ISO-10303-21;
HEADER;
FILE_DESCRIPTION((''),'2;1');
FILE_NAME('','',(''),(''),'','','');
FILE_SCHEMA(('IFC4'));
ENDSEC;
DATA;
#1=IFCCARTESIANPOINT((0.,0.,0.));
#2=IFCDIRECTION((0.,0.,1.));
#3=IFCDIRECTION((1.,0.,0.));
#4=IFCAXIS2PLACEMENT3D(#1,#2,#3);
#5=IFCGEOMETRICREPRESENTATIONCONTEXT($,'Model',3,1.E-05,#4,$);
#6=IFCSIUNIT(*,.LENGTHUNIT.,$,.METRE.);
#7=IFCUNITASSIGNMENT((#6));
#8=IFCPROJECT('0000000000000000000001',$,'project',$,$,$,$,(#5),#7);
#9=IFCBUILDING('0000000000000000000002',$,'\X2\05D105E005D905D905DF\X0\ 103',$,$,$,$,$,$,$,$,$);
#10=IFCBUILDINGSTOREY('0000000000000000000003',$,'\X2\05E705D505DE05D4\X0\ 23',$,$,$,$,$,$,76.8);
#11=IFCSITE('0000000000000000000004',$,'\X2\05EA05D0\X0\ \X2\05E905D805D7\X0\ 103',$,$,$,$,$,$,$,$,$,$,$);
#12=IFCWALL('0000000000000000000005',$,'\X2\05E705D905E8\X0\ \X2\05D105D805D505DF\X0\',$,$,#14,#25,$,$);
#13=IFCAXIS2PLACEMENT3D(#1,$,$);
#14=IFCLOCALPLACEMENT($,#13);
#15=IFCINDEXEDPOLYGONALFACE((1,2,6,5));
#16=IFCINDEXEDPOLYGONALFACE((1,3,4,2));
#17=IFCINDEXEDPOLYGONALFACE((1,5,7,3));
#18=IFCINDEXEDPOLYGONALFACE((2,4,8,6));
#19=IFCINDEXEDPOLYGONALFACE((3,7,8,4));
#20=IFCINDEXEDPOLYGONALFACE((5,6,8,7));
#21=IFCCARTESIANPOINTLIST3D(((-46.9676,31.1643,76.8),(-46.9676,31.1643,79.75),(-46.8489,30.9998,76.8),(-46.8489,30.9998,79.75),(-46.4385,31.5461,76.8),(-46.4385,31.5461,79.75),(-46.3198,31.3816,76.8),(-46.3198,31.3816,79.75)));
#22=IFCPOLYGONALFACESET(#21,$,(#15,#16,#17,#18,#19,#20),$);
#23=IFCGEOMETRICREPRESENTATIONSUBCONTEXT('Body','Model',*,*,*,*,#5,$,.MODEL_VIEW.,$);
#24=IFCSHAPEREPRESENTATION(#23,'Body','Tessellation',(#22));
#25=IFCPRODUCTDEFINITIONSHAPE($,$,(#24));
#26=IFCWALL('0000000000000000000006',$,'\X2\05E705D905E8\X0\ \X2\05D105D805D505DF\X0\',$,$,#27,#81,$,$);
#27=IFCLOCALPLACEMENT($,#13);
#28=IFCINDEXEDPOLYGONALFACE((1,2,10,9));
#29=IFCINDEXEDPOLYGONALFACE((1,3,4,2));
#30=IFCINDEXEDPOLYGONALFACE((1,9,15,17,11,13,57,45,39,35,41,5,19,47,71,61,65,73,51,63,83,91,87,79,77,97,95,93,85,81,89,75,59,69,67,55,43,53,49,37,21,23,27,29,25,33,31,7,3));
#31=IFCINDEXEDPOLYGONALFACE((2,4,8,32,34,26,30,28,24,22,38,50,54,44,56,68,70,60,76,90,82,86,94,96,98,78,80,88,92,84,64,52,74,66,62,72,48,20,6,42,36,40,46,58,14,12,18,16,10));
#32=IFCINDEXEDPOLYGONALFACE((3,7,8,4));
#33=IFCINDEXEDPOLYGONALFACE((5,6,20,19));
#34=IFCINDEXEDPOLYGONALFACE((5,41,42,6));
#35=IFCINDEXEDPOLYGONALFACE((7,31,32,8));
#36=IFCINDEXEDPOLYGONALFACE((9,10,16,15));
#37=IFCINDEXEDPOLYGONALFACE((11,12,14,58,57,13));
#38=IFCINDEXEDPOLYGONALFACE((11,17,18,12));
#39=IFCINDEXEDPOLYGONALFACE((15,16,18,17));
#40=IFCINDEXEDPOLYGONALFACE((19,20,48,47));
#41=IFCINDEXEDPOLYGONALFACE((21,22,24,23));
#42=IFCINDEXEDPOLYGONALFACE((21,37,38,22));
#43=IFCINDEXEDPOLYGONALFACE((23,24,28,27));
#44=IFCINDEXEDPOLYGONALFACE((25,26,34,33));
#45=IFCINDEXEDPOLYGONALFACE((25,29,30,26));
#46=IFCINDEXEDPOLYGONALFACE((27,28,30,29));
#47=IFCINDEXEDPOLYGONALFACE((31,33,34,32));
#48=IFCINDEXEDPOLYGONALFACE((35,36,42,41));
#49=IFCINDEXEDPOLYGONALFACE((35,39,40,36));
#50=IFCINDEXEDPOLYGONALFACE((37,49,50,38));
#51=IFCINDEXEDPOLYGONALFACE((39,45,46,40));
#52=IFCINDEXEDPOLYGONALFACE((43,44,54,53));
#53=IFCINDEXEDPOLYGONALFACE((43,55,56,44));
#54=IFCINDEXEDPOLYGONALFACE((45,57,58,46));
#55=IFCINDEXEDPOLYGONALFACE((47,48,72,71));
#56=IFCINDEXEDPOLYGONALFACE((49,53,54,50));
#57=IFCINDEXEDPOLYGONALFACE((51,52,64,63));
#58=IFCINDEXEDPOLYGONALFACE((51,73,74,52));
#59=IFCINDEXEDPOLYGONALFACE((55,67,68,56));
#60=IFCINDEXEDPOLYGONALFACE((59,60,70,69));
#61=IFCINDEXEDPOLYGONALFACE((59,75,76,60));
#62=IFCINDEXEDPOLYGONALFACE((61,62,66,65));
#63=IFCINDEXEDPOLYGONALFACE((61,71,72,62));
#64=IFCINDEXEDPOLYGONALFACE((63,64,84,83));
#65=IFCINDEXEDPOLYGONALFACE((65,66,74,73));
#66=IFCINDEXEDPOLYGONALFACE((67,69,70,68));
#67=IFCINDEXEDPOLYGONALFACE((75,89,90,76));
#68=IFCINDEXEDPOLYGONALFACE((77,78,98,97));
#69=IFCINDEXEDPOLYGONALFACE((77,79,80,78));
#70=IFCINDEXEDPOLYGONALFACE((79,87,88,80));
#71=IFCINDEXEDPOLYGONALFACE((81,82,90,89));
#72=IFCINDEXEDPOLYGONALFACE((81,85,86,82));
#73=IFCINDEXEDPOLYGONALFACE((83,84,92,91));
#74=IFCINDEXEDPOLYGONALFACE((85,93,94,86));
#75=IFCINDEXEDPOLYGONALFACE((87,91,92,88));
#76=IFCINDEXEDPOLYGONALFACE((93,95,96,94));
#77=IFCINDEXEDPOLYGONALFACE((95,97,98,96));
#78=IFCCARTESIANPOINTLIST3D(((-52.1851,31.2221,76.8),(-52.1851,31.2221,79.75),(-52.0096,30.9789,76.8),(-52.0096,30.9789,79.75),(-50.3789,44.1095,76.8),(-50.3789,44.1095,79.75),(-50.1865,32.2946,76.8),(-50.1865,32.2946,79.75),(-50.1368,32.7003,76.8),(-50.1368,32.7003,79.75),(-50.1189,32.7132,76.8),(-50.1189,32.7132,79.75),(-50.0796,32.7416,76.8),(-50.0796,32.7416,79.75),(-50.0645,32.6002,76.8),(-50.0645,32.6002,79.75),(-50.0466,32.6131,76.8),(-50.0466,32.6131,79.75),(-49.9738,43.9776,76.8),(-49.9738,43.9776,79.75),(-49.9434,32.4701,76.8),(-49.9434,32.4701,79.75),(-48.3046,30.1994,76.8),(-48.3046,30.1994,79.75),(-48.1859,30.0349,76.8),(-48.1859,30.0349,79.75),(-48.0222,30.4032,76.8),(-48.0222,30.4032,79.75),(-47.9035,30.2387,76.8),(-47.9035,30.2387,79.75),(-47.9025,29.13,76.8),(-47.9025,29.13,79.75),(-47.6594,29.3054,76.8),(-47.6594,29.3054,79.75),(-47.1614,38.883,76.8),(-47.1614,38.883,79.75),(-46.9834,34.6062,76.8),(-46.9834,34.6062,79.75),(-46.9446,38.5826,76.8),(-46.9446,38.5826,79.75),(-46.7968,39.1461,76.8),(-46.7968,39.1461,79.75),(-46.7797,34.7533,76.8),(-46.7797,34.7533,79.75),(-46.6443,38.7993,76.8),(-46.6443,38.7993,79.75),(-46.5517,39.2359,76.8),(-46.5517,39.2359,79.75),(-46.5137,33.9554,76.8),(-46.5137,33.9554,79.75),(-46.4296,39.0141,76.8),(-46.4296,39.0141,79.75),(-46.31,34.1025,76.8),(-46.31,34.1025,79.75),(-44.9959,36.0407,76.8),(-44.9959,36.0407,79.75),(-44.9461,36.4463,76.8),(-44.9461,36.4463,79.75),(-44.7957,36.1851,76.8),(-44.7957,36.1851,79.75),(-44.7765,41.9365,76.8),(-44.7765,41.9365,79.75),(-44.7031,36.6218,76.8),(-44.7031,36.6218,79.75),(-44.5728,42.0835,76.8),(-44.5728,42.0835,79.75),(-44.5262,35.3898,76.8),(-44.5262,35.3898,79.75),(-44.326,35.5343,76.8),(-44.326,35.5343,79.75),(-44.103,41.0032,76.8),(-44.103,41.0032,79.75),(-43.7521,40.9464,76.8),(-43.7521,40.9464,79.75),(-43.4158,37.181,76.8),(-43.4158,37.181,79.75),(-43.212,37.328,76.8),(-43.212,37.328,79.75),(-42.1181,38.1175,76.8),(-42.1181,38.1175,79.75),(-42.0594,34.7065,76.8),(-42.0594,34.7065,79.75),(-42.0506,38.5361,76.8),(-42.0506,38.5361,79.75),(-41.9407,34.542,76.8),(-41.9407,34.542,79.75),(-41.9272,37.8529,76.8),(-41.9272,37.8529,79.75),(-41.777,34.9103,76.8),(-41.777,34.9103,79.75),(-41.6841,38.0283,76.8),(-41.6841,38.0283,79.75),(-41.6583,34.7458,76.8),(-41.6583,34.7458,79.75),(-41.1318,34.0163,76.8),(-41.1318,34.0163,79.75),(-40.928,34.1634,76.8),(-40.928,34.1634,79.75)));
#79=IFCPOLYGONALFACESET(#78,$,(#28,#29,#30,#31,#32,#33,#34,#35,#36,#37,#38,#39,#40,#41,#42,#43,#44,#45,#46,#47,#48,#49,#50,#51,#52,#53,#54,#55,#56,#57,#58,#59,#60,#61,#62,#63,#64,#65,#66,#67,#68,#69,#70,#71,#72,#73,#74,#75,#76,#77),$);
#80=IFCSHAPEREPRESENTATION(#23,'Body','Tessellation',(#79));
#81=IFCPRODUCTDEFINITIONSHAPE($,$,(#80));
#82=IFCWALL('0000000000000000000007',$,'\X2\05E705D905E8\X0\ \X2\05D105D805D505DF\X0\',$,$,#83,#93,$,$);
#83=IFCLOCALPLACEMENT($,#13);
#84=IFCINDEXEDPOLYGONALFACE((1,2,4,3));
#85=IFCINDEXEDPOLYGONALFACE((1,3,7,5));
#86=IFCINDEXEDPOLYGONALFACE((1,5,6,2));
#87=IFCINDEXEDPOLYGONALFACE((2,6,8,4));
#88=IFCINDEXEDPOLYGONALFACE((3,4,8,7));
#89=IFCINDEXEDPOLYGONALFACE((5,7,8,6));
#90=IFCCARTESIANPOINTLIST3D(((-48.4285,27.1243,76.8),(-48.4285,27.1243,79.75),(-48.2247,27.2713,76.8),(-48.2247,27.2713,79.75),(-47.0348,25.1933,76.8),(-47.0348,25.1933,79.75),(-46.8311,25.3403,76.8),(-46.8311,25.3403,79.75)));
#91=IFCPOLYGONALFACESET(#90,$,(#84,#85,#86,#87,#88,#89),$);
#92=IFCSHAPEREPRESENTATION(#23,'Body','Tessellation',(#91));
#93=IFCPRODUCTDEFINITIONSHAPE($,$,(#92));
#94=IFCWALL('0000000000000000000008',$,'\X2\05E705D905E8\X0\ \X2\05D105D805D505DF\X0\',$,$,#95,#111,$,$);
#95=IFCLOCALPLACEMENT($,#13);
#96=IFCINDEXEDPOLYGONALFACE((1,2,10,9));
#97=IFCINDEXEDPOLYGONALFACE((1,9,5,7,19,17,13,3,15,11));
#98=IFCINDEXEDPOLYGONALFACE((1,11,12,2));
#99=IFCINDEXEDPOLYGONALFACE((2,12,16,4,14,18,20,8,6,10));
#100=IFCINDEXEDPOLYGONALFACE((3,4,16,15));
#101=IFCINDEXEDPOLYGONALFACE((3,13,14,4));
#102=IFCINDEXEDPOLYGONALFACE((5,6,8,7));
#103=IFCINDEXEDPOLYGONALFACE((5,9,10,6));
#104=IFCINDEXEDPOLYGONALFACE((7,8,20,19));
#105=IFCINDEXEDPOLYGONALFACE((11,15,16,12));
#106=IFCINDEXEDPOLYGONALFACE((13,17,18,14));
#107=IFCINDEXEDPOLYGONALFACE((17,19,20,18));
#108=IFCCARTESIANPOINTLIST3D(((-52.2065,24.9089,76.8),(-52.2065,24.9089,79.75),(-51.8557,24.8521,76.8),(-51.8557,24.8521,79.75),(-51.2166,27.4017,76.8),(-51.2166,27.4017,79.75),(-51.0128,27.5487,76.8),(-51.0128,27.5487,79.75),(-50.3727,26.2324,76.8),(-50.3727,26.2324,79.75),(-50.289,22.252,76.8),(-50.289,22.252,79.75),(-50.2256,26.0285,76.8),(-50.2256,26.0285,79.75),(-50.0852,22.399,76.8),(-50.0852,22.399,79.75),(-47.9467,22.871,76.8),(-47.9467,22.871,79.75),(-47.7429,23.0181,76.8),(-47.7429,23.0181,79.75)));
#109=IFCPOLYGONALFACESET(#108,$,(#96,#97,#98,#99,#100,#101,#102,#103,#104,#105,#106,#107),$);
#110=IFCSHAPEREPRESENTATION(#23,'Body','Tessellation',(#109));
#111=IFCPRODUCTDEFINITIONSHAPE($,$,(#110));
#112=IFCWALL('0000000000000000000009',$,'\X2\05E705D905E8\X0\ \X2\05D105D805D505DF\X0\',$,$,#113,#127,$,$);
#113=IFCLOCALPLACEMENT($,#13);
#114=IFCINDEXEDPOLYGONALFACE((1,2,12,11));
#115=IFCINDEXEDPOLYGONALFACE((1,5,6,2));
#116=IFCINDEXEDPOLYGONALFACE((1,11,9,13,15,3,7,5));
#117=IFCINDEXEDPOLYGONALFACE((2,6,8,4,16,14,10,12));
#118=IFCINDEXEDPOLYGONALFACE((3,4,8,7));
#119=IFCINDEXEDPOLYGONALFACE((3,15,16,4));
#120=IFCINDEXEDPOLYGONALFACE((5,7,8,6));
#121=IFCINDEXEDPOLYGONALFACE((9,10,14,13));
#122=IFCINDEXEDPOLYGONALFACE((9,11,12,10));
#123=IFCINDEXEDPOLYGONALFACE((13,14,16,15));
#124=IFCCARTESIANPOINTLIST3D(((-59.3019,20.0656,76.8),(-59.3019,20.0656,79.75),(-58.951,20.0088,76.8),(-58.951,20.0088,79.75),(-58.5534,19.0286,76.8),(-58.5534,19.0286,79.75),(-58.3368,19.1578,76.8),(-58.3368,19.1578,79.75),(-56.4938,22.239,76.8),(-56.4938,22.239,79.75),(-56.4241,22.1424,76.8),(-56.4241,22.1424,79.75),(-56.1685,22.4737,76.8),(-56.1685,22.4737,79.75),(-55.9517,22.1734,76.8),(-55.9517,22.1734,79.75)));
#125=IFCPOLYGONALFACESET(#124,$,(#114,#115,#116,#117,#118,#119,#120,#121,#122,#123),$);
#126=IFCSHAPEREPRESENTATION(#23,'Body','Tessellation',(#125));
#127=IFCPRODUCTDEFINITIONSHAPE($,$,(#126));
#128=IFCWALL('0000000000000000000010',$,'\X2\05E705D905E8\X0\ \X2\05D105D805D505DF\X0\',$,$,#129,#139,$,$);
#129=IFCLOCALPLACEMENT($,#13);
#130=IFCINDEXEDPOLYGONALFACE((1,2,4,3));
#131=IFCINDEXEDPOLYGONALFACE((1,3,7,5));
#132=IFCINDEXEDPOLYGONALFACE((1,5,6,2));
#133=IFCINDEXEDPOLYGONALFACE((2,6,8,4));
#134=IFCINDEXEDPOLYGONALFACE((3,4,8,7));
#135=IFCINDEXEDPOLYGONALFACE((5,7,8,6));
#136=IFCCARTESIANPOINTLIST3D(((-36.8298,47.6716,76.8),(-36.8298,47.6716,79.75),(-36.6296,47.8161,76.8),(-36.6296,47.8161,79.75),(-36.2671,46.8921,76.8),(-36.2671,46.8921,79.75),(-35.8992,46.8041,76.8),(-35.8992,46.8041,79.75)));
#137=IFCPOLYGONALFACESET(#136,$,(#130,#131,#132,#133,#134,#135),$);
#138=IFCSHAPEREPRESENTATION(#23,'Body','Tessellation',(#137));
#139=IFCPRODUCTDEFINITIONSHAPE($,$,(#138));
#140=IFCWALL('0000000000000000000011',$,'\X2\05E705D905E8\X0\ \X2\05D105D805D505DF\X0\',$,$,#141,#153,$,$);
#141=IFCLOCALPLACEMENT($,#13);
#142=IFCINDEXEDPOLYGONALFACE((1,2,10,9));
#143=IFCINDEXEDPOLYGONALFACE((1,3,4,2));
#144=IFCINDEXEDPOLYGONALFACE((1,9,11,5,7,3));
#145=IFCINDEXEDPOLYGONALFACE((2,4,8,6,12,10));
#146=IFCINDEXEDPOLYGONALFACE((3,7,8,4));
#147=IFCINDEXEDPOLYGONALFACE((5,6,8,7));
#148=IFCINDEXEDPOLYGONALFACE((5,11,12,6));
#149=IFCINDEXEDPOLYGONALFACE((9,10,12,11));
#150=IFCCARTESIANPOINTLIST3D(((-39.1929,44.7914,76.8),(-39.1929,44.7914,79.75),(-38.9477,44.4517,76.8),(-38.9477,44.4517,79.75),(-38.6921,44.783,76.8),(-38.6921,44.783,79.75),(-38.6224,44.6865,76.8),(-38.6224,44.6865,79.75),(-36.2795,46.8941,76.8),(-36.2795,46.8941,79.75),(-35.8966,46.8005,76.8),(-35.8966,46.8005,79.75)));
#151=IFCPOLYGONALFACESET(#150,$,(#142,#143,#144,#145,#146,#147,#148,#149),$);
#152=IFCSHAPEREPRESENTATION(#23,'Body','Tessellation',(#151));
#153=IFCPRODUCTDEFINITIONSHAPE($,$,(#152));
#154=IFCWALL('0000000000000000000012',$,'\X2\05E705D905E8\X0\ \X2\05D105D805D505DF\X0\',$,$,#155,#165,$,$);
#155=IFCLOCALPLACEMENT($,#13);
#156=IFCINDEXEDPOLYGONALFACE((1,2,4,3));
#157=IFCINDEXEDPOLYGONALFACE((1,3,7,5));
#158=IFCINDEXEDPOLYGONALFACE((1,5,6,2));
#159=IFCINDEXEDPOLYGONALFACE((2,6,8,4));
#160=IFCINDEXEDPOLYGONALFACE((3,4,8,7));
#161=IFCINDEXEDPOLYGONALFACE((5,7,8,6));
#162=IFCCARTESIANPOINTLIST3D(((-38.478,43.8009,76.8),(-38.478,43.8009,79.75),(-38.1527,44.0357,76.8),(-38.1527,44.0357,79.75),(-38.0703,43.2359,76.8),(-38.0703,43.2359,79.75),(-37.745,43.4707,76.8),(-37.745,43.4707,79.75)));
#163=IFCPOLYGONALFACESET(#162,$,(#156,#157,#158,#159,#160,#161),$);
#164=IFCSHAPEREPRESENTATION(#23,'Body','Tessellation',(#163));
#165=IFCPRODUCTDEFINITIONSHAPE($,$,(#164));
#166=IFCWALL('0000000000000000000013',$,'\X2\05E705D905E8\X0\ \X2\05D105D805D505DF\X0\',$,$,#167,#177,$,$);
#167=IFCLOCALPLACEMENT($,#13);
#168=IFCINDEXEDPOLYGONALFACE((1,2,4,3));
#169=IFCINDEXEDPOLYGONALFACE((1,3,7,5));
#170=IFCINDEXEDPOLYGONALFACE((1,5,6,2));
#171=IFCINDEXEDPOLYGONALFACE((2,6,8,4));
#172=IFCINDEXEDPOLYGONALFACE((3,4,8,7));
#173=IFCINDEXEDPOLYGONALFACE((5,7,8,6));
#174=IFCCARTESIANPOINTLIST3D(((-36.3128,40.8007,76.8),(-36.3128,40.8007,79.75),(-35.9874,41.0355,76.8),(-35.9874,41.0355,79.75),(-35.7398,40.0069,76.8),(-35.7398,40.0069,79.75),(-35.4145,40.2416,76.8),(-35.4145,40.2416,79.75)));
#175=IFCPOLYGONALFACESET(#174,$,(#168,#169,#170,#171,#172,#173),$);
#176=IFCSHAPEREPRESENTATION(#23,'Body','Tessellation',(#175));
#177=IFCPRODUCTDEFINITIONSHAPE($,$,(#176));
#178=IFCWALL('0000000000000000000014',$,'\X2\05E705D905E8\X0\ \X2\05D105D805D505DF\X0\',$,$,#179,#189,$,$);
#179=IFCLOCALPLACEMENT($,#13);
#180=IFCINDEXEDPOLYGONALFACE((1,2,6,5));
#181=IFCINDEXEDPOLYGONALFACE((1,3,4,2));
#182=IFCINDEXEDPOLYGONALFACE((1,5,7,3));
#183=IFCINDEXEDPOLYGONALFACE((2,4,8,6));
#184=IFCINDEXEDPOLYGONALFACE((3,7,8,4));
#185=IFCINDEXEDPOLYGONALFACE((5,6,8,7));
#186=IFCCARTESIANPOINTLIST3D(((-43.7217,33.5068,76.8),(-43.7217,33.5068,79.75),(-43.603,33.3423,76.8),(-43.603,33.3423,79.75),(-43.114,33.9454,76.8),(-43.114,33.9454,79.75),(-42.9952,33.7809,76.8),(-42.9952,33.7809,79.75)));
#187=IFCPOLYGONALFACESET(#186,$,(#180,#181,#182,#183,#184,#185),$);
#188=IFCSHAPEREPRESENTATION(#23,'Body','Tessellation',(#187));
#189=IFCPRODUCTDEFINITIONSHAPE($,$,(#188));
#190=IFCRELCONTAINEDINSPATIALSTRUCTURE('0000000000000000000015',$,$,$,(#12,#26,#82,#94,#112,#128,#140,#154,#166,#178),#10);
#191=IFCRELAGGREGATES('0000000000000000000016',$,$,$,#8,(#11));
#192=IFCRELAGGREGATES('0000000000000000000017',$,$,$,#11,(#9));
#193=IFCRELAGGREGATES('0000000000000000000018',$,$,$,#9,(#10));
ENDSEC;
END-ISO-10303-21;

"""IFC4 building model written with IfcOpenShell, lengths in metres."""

from ifc_helpers import new_model, si_unit, frame, origin_with_axes, context, subcontext, project, spatial, polyline, outline, extrude, element, save


model = new_model("IFC4")

# Units and contexts
model_context = context("Model", 3, precision=1e-05, world=origin_with_axes())
body_context = subcontext(model_context, "Body", "Model", "MODEL_VIEW")
ifc_project = project(units=[si_unit("LENGTHUNIT", "METRE")], contexts=[model_context])

# Site, building, storey
site = spatial("IfcSite", under=ifc_project, Name="תא שטח 103")
building = spatial("IfcBuilding", under=site, Name="בניין 103")
storey = spatial("IfcBuildingStorey", under=building, Name="קומה 23", Elevation=76.8)

# Walls
element("IfcWall", 1, inside=storey, Name="קיר בטון", context=body_context, shape_type="SweptSolid", body=[
    extrude(outline(polyline([(-46.3198, 31.3816), (-46.8489, 30.9998), (-46.9676, 31.1643), (-46.4385, 31.5461), (-46.3198, 31.3816)])), frame((0.0, 0.0, 76.8)), (0.0, 0.0, 1.0), 2.95),
])
element("IfcWall", 2, inside=storey, Name="קיר בטון", context=body_context, shape_type="SweptSolid", body=[
    extrude(outline(polyline([(-47.9035, 30.2387), (-48.1859, 30.0349), (-47.6594, 29.3054), (-47.9025, 29.13), (-50.1865, 32.2946), (-52.0096, 30.9789), (-52.1851, 31.2221), (-50.1368, 32.7003), (-50.0645, 32.6002), (-50.0466, 32.6131), (-50.1189, 32.7132), (-50.0796, 32.7416), (-44.9461, 36.4463), (-46.6443, 38.7993), (-46.9446, 38.5826), (-47.1614, 38.883), (-46.7968, 39.1461), (-50.3789, 44.1095), (-49.9738, 43.9776), (-46.5517, 39.2359), (-44.103, 41.0032), (-44.7765, 41.9365), (-44.5728, 42.0835), (-43.7521, 40.9464), (-46.4296, 39.0141), (-44.7031, 36.6218), (-42.0506, 38.5361), (-41.6841, 38.0283), (-41.9272, 37.8529), (-42.1181, 38.1175), (-43.212, 37.328), (-40.928, 34.1634), (-41.1318, 34.0163), (-41.6583, 34.7458), (-41.9407, 34.542), (-42.0594, 34.7065), (-41.777, 34.9103), (-43.4158, 37.181), (-44.7957, 36.1851), (-44.326, 35.5343), (-44.5262, 35.3898), (-44.9959, 36.0407), (-46.7797, 34.7533), (-46.31, 34.1025), (-46.5137, 33.9554), (-46.9834, 34.6062), (-49.9434, 32.4701), (-48.3046, 30.1994), (-48.0222, 30.4032), (-47.9035, 30.2387)])), frame((0.0, 0.0, 76.8)), (0.0, 0.0, 1.0), 2.95),
])
element("IfcWall", 3, inside=storey, Name="קיר בטון", context=body_context, shape_type="SweptSolid", body=[
    extrude(outline(polyline([(-48.2247, 27.2713), (-46.8311, 25.3403), (-47.0348, 25.1933), (-48.4285, 27.1243), (-48.2247, 27.2713)])), frame((0.0, 0.0, 76.8)), (0.0, 0.0, 1.0), 2.95),
])
element("IfcWall", 4, inside=storey, Name="קיר בטון", context=body_context, shape_type="SweptSolid", body=[
    extrude(outline(polyline([(-50.289, 22.252), (-52.2065, 24.9089), (-50.3727, 26.2324), (-51.2166, 27.4017), (-51.0128, 27.5487), (-47.7429, 23.0181), (-47.9467, 22.871), (-50.2256, 26.0285), (-51.8557, 24.8521), (-50.0852, 22.399), (-50.289, 22.252)])), frame((0.0, 0.0, 76.8)), (0.0, 0.0, 1.0), 2.95),
])
element("IfcWall", 5, inside=storey, Name="קיר בטון", context=body_context, shape_type="SweptSolid", body=[
    extrude(outline(polyline([(-58.951, 20.0088), (-58.3368, 19.1578), (-58.5534, 19.0286), (-59.3019, 20.0656), (-56.4241, 22.1424), (-56.4938, 22.239), (-56.1685, 22.4737), (-55.9517, 22.1734), (-58.951, 20.0088)])), frame((0.0, 0.0, 76.8)), (0.0, 0.0, 1.0), 2.95),
])
element("IfcWall", 6, inside=storey, Name="קיר בטון", context=body_context, shape_type="SweptSolid", body=[
    extrude(outline(polyline([(-36.2671, 46.8921), (-36.8298, 47.6716), (-36.6296, 47.8161), (-35.8992, 46.8041), (-36.2671, 46.8921)])), frame((0.0, 0.0, 76.8)), (0.0, 0.0, 1.0), 2.95),
])
element("IfcWall", 7, inside=storey, Name="קיר בטון", context=body_context, shape_type="SweptSolid", body=[
    extrude(outline(polyline([(-38.9477, 44.4517), (-39.1929, 44.7914), (-36.2795, 46.8941), (-35.8966, 46.8005), (-38.6921, 44.783), (-38.6224, 44.6865), (-38.9477, 44.4517)])), frame((0.0, 0.0, 76.8)), (0.0, 0.0, 1.0), 2.95),
])
element("IfcWall", 8, inside=storey, Name="קיר בטון", context=body_context, shape_type="SweptSolid", body=[
    extrude(outline(polyline([(-38.0703, 43.2359), (-38.478, 43.8009), (-38.1527, 44.0357), (-37.745, 43.4707), (-38.0703, 43.2359)])), frame((0.0, 0.0, 76.8)), (0.0, 0.0, 1.0), 2.95),
])
element("IfcWall", 9, inside=storey, Name="קיר בטון", context=body_context, shape_type="SweptSolid", body=[
    extrude(outline(polyline([(-36.3128, 40.8007), (-35.9874, 41.0355), (-35.4145, 40.2416), (-35.7398, 40.0069), (-36.3128, 40.8007)])), frame((0.0, 0.0, 76.8)), (0.0, 0.0, 1.0), 2.95),
])
element("IfcWall", 10, inside=storey, Name="קיר בטון", context=body_context, shape_type="SweptSolid", body=[
    extrude(outline(polyline([(-43.7217, 33.5068), (-43.114, 33.9454), (-42.9952, 33.7809), (-43.603, 33.3423), (-43.7217, 33.5068)])), frame((0.0, 0.0, 76.8)), (0.0, 0.0, 1.0), 2.95),
])

save(model, "model.ifc")
